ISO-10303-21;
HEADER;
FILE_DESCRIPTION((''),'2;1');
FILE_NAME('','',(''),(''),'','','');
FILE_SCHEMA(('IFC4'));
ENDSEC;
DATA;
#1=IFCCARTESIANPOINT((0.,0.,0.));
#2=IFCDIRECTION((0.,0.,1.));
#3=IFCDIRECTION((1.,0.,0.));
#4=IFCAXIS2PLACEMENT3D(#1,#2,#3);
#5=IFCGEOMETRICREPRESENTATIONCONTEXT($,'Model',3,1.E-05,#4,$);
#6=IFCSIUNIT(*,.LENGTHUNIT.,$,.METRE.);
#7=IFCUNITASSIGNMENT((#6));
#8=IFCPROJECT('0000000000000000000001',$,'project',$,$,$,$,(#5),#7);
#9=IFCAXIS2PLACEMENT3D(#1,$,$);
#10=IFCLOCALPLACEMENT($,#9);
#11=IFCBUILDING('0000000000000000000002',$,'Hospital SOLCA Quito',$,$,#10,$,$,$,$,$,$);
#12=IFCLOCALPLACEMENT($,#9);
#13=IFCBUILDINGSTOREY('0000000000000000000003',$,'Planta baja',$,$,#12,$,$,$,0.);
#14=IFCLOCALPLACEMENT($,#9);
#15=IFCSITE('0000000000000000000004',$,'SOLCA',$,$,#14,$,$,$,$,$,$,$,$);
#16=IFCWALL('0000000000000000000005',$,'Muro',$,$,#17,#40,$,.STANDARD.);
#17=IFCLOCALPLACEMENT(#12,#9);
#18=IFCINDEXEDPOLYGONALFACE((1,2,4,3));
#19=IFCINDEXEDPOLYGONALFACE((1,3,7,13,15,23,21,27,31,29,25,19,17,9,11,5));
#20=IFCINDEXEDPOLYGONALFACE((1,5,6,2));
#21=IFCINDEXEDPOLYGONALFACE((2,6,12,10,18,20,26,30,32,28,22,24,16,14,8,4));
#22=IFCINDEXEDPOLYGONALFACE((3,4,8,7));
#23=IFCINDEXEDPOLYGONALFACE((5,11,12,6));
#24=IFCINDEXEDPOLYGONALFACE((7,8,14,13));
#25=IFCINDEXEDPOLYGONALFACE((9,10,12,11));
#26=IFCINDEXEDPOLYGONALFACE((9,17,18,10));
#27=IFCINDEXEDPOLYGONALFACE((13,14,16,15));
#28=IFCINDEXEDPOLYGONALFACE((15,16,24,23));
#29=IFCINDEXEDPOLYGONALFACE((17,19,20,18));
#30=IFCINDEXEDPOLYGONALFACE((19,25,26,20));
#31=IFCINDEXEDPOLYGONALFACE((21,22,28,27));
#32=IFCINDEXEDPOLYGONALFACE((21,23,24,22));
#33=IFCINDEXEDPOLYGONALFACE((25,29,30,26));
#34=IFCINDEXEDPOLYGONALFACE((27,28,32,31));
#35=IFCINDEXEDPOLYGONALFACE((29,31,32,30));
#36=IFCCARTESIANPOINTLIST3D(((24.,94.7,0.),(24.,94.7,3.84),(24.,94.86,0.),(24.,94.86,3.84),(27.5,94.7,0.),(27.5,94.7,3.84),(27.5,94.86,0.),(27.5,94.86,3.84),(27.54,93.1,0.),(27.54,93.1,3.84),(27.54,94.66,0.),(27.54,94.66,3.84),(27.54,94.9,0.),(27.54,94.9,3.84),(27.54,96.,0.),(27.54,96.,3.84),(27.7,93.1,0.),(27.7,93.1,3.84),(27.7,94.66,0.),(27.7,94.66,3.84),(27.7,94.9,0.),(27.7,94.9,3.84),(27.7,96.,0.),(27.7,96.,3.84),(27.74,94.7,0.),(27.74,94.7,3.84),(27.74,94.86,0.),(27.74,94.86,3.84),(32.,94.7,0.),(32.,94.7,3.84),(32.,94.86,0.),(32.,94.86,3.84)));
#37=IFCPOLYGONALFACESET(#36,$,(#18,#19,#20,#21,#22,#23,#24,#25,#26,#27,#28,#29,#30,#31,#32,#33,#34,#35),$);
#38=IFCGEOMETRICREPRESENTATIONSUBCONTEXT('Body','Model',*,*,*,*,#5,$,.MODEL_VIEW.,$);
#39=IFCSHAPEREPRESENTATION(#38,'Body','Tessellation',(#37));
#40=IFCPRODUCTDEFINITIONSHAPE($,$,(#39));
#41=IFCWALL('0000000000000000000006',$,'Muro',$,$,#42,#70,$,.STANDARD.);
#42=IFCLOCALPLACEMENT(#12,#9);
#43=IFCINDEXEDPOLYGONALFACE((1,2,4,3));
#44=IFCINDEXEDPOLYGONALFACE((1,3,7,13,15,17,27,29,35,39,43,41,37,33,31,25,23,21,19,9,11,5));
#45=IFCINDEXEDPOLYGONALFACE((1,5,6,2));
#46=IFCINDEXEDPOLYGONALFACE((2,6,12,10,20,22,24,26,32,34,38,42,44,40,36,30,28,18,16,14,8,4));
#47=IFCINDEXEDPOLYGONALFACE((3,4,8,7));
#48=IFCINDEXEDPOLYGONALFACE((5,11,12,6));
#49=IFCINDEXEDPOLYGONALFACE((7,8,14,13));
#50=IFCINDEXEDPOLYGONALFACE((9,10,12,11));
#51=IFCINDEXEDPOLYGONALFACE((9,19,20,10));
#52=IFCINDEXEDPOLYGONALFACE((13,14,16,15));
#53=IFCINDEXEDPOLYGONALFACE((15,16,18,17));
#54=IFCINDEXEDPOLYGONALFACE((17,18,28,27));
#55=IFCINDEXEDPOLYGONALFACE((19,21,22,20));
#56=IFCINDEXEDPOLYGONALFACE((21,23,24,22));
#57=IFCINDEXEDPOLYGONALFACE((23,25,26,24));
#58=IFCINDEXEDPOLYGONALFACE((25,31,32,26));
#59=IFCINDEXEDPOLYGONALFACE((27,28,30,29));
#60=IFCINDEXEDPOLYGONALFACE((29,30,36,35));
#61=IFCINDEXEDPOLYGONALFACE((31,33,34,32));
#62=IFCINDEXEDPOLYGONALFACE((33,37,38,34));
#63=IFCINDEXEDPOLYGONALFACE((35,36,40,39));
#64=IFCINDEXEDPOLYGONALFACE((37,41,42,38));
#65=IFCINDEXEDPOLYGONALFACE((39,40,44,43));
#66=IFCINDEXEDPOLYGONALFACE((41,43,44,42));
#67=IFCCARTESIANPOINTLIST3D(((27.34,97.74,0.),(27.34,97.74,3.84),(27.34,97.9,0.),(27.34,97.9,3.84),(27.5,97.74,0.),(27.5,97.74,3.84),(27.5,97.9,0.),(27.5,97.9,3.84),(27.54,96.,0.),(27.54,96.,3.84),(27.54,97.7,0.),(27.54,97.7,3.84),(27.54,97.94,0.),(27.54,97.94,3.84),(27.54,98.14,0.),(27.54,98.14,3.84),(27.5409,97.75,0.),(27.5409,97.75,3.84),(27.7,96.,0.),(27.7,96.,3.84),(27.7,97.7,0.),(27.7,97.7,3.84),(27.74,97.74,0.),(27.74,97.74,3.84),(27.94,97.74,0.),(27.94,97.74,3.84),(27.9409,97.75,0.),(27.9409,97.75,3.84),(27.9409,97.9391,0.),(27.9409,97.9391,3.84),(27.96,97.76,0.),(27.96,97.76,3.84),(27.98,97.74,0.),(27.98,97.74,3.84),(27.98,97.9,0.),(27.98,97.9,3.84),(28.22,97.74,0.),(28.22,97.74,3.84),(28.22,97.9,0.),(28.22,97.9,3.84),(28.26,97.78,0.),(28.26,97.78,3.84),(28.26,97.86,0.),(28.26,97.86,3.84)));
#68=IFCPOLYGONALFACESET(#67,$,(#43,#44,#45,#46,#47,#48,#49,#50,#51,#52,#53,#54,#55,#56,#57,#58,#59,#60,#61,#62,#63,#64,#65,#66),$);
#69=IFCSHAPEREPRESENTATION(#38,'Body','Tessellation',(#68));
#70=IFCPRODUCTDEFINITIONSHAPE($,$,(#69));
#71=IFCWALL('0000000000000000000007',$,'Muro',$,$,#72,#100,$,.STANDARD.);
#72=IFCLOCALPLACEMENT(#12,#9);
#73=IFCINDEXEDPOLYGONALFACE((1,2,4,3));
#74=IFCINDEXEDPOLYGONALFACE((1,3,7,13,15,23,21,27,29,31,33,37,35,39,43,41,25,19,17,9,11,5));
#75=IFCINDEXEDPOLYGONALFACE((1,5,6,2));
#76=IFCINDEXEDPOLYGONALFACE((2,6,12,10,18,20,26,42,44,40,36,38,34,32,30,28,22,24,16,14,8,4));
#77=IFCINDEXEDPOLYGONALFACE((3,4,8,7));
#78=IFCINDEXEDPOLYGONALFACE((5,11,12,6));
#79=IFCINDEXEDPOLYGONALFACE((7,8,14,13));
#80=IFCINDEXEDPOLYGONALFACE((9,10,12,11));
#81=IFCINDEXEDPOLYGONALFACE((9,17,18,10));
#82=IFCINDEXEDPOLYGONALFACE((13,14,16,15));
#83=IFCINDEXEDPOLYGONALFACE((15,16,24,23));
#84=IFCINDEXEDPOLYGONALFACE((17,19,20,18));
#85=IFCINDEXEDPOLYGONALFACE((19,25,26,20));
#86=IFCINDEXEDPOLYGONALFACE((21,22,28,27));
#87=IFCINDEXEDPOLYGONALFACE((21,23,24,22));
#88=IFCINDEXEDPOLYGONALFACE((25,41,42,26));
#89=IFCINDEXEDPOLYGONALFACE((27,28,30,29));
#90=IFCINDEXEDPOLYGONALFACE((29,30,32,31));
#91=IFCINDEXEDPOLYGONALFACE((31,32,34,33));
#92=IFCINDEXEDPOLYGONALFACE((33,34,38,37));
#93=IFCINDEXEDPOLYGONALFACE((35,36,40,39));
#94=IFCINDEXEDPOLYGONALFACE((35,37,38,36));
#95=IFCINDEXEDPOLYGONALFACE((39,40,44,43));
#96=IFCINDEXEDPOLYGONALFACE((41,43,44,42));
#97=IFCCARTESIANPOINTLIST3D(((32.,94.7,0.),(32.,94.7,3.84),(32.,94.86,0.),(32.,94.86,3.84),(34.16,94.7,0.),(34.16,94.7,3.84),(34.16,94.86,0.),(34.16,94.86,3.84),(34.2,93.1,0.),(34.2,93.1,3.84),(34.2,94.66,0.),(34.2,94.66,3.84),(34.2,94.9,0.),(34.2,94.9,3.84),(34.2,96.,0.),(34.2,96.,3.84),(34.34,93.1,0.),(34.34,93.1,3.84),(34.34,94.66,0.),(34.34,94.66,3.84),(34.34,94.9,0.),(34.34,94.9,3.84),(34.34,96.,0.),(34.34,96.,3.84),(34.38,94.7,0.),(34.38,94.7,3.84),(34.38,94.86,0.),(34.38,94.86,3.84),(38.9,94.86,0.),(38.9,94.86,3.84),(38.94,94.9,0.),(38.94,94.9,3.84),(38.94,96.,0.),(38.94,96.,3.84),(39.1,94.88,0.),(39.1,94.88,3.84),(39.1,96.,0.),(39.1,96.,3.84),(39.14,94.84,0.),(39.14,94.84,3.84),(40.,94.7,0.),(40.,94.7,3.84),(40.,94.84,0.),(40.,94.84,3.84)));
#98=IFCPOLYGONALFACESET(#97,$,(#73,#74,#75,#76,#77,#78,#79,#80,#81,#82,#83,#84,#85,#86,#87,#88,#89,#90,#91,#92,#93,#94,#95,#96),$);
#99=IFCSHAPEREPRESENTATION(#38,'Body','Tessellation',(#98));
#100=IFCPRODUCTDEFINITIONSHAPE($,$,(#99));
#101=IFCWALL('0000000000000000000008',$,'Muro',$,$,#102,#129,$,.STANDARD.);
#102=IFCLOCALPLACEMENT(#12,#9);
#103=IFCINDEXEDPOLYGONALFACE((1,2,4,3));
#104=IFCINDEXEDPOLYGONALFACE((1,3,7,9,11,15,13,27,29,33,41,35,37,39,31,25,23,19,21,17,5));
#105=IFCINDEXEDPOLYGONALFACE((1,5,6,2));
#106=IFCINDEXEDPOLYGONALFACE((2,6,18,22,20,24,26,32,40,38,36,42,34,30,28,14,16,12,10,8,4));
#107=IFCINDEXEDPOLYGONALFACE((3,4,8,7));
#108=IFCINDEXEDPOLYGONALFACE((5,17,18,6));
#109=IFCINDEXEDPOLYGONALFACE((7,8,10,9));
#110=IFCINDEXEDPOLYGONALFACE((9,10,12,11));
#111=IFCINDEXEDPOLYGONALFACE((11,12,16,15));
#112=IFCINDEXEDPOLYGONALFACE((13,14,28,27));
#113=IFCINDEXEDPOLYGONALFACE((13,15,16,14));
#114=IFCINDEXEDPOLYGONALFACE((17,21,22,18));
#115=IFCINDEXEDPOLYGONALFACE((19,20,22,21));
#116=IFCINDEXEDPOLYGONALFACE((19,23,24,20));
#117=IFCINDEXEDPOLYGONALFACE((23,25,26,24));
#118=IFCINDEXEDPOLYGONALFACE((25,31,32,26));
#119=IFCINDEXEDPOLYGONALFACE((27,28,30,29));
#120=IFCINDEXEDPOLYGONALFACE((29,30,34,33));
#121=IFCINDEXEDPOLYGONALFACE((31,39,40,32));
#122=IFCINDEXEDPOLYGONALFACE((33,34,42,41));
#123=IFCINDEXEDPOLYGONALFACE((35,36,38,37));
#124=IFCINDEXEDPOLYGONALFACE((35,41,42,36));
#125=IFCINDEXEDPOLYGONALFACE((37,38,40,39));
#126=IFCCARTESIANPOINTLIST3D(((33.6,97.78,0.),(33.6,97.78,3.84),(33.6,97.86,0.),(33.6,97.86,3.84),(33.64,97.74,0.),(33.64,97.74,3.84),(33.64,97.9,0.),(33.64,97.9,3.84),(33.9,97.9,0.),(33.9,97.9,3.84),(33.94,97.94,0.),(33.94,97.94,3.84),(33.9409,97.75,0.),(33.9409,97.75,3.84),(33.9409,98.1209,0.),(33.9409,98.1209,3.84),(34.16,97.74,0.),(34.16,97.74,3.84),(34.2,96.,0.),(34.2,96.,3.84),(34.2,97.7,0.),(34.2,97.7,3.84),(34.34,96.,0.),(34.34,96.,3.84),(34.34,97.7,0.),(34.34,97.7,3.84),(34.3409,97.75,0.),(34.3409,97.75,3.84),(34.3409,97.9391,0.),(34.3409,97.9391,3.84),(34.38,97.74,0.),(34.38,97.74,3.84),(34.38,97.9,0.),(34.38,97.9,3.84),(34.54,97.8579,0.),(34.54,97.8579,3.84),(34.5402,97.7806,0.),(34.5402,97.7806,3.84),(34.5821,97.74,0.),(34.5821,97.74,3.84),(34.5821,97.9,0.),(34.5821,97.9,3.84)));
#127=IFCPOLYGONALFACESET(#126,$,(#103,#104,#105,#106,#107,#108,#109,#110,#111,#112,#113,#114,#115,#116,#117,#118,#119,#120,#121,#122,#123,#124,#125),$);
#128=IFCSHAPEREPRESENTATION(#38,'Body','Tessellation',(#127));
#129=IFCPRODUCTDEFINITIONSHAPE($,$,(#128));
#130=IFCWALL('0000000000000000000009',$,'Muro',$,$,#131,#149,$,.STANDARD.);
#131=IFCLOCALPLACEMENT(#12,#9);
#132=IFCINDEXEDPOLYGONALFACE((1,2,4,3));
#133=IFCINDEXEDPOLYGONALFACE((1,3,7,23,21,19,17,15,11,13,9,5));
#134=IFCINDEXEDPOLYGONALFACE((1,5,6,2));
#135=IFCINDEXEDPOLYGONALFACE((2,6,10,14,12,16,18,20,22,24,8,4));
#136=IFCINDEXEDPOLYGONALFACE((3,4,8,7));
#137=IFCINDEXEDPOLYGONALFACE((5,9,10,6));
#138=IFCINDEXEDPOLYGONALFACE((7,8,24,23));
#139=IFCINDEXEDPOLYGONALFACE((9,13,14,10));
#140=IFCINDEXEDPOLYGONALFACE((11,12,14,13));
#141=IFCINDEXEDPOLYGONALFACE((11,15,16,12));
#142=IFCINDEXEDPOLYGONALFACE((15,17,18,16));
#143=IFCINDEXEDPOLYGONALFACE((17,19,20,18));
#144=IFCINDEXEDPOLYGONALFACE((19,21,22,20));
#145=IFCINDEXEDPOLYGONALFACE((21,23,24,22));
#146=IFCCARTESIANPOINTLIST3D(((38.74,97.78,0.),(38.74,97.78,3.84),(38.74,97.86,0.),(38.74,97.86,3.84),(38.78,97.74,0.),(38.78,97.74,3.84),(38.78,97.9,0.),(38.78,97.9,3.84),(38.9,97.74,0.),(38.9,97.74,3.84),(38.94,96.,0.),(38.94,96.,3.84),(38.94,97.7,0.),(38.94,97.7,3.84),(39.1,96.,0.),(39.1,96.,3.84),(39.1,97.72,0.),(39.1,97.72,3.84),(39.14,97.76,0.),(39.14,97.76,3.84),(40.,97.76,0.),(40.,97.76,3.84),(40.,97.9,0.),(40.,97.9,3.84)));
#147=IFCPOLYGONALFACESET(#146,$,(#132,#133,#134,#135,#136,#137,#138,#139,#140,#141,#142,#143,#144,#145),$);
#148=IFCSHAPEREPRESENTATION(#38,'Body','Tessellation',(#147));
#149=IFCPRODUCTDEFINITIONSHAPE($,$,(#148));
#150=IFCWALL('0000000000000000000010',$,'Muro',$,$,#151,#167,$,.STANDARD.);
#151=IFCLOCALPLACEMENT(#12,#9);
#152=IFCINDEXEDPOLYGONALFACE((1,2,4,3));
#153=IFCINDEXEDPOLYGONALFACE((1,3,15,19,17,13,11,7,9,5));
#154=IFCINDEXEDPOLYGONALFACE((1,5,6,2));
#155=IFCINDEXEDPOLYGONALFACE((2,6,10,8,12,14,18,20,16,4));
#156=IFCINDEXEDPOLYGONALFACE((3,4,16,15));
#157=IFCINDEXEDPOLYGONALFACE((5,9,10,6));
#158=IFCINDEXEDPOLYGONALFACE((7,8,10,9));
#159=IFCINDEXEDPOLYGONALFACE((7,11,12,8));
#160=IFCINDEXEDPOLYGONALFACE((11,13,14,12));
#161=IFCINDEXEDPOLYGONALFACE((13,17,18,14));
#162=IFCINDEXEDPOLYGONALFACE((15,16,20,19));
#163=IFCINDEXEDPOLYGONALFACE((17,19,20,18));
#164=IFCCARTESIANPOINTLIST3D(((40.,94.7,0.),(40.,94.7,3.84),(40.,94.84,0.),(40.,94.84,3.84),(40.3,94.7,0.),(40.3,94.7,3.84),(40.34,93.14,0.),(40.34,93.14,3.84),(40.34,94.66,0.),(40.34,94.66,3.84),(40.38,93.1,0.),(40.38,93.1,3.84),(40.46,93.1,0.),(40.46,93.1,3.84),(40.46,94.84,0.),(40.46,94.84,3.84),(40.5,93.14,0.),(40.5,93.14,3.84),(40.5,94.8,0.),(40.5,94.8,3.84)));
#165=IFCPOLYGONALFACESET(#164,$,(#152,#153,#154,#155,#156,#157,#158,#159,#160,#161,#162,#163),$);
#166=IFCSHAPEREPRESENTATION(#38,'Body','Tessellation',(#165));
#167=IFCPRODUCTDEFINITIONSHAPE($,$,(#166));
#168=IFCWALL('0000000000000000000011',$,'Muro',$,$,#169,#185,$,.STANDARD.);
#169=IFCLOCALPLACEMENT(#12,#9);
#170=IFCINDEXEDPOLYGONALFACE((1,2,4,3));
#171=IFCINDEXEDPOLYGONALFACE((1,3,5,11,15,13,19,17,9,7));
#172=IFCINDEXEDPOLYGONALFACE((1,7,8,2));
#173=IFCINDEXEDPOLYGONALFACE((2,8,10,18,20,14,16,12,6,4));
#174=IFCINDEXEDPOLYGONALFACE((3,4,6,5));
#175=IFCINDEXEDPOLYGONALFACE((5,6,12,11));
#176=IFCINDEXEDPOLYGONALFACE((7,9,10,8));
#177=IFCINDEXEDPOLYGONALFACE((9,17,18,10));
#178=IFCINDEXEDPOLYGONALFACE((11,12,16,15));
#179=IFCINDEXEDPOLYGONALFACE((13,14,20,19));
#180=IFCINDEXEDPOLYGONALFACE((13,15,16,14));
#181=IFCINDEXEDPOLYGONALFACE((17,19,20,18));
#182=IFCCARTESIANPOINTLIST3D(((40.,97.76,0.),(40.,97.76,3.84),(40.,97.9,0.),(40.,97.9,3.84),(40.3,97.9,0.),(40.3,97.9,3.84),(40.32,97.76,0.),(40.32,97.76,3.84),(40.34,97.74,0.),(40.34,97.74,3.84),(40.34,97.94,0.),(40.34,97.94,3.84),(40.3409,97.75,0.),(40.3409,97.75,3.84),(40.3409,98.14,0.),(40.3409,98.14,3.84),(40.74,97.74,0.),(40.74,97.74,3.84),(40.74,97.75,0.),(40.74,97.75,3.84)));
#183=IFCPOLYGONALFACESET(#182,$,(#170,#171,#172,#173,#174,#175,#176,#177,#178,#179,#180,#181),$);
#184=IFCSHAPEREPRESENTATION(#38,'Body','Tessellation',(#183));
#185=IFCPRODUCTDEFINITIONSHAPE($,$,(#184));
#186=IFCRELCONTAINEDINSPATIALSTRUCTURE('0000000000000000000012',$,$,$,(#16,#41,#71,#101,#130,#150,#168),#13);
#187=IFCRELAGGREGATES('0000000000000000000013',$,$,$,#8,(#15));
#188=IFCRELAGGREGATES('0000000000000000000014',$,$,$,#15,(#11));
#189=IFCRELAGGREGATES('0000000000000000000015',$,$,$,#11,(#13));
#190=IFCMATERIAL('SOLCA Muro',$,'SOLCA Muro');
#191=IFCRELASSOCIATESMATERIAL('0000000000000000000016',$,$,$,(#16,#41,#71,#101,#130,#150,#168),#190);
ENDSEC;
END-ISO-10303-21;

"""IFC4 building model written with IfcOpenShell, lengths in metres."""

from ifc_helpers import new_model, si_unit, origin, origin_with_axes, place, context, subcontext, project, spatial, polyline, outline, extrude, material, element, save


model = new_model("IFC4")

# Units and contexts
model_context = context("Model", 3, precision=1e-05, world=origin_with_axes())
body_context = subcontext(model_context, "Body", "Model", "MODEL_VIEW")
ifc_project = project(units=[si_unit("LENGTHUNIT", "METRE")], contexts=[model_context])

# Site, building, storey
site_placement = place(None, origin())
site = spatial("IfcSite", under=ifc_project, at=site_placement, Name="SOLCA")
building_placement = place(None, origin())
building = spatial("IfcBuilding", under=site, at=building_placement, Name="Hospital SOLCA Quito")
storey_placement = place(None, origin())
storey = spatial("IfcBuildingStorey", under=building, at=storey_placement, Name="Planta baja", Elevation=0.0)

# Walls
ifc_material = material(Name="SOLCA Muro", Category="SOLCA Muro")
wall_1_placement = place(storey_placement, origin_with_axes())
element("IfcWall", 1, at=wall_1_placement, inside=storey, material=ifc_material, Name="Muro", PredefinedType="STANDARD", context=body_context, shape_type="SweptSolid", body=[
    extrude(outline(polyline([(27.7, 94.9), (27.74, 94.86), (32.0, 94.86), (32.0, 94.7), (27.74, 94.7), (27.7, 94.66), (27.7, 93.1), (27.54, 93.1), (27.54, 94.66), (27.5, 94.7), (24.0, 94.7), (24.0, 94.86), (27.5, 94.86), (27.54, 94.9), (27.54, 96.0), (27.7, 96.0), (27.7, 94.9)])), origin_with_axes(), (0.0, 0.0, 1.0), 3.84),
])
wall_2_placement = place(storey_placement, origin_with_axes())
element("IfcWall", 2, at=wall_2_placement, inside=storey, material=ifc_material, Name="Muro", PredefinedType="STANDARD", context=body_context, shape_type="SweptSolid", body=[
    extrude(outline(polyline([(27.34, 97.74), (27.34, 97.9), (27.5, 97.9), (27.54, 97.94), (27.54, 98.14), (27.5409, 97.75), (27.9409, 97.75), (27.9409, 97.9391), (27.98, 97.9), (28.22, 97.9), (28.26, 97.86), (28.26, 97.78), (28.22, 97.74), (27.98, 97.74), (27.96, 97.76), (27.94, 97.74), (27.74, 97.74), (27.7, 97.7), (27.7, 96.0), (27.54, 96.0), (27.54, 97.7), (27.5, 97.74), (27.34, 97.74)])), origin_with_axes(), (0.0, 0.0, 1.0), 3.84),
])
wall_3_placement = place(storey_placement, origin_with_axes())
element("IfcWall", 3, at=wall_3_placement, inside=storey, material=ifc_material, Name="Muro", PredefinedType="STANDARD", context=body_context, shape_type="SweptSolid", body=[
    extrude(outline(polyline([(34.16, 94.86), (34.2, 94.9), (34.2, 96.0), (34.34, 96.0), (34.34, 94.9), (34.38, 94.86), (38.9, 94.86), (38.94, 94.9), (38.94, 96.0), (39.1, 96.0), (39.1, 94.88), (39.14, 94.84), (40.0, 94.84), (40.0, 94.7), (34.38, 94.7), (34.34, 94.66), (34.34, 93.1), (34.2, 93.1), (34.2, 94.66), (34.16, 94.7), (32.0, 94.7), (32.0, 94.86), (34.16, 94.86)])), origin_with_axes(), (0.0, 0.0, 1.0), 3.84),
])
wall_4_placement = place(storey_placement, origin_with_axes())
element("IfcWall", 4, at=wall_4_placement, inside=storey, material=ifc_material, Name="Muro", PredefinedType="STANDARD", context=body_context, shape_type="SweptSolid", body=[
    extrude(outline(polyline([(34.2, 97.7), (34.16, 97.74), (33.64, 97.74), (33.6, 97.78), (33.6, 97.86), (33.64, 97.9), (33.9, 97.9), (33.94, 97.94), (33.9409, 98.1209), (33.9409, 97.75), (34.3409, 97.75), (34.3409, 97.9391), (34.38, 97.9), (34.5821, 97.9), (34.54, 97.8579), (34.5402, 97.7806), (34.5821, 97.74), (34.38, 97.74), (34.34, 97.7), (34.34, 96.0), (34.2, 96.0), (34.2, 97.7)])), origin_with_axes(), (0.0, 0.0, 1.0), 3.84),
])
wall_5_placement = place(storey_placement, origin_with_axes())
element("IfcWall", 5, at=wall_5_placement, inside=storey, material=ifc_material, Name="Muro", PredefinedType="STANDARD", context=body_context, shape_type="SweptSolid", body=[
    extrude(outline(polyline([(38.94, 97.7), (38.9, 97.74), (38.78, 97.74), (38.74, 97.78), (38.74, 97.86), (38.78, 97.9), (40.0, 97.9), (40.0, 97.76), (39.14, 97.76), (39.1, 97.72), (39.1, 96.0), (38.94, 96.0), (38.94, 97.7)])), origin_with_axes(), (0.0, 0.0, 1.0), 3.84),
])
wall_6_placement = place(storey_placement, origin_with_axes())
element("IfcWall", 6, at=wall_6_placement, inside=storey, material=ifc_material, Name="Muro", PredefinedType="STANDARD", context=body_context, shape_type="SweptSolid", body=[
    extrude(outline(polyline([(40.46, 94.84), (40.5, 94.8), (40.5, 93.14), (40.46, 93.1), (40.38, 93.1), (40.34, 93.14), (40.34, 94.66), (40.3, 94.7), (40.0, 94.7), (40.0, 94.84), (40.46, 94.84)])), origin_with_axes(), (0.0, 0.0, 1.0), 3.84),
])
wall_7_placement = place(storey_placement, origin_with_axes())
element("IfcWall", 7, at=wall_7_placement, inside=storey, material=ifc_material, Name="Muro", PredefinedType="STANDARD", context=body_context, shape_type="SweptSolid", body=[
    extrude(outline(polyline([(40.3, 97.9), (40.34, 97.94), (40.3409, 98.14), (40.3409, 97.75), (40.74, 97.75), (40.74, 97.74), (40.34, 97.74), (40.32, 97.76), (40.0, 97.76), (40.0, 97.9), (40.3, 97.9)])), origin_with_axes(), (0.0, 0.0, 1.0), 3.84),
])

save(model, "model.ifc")
